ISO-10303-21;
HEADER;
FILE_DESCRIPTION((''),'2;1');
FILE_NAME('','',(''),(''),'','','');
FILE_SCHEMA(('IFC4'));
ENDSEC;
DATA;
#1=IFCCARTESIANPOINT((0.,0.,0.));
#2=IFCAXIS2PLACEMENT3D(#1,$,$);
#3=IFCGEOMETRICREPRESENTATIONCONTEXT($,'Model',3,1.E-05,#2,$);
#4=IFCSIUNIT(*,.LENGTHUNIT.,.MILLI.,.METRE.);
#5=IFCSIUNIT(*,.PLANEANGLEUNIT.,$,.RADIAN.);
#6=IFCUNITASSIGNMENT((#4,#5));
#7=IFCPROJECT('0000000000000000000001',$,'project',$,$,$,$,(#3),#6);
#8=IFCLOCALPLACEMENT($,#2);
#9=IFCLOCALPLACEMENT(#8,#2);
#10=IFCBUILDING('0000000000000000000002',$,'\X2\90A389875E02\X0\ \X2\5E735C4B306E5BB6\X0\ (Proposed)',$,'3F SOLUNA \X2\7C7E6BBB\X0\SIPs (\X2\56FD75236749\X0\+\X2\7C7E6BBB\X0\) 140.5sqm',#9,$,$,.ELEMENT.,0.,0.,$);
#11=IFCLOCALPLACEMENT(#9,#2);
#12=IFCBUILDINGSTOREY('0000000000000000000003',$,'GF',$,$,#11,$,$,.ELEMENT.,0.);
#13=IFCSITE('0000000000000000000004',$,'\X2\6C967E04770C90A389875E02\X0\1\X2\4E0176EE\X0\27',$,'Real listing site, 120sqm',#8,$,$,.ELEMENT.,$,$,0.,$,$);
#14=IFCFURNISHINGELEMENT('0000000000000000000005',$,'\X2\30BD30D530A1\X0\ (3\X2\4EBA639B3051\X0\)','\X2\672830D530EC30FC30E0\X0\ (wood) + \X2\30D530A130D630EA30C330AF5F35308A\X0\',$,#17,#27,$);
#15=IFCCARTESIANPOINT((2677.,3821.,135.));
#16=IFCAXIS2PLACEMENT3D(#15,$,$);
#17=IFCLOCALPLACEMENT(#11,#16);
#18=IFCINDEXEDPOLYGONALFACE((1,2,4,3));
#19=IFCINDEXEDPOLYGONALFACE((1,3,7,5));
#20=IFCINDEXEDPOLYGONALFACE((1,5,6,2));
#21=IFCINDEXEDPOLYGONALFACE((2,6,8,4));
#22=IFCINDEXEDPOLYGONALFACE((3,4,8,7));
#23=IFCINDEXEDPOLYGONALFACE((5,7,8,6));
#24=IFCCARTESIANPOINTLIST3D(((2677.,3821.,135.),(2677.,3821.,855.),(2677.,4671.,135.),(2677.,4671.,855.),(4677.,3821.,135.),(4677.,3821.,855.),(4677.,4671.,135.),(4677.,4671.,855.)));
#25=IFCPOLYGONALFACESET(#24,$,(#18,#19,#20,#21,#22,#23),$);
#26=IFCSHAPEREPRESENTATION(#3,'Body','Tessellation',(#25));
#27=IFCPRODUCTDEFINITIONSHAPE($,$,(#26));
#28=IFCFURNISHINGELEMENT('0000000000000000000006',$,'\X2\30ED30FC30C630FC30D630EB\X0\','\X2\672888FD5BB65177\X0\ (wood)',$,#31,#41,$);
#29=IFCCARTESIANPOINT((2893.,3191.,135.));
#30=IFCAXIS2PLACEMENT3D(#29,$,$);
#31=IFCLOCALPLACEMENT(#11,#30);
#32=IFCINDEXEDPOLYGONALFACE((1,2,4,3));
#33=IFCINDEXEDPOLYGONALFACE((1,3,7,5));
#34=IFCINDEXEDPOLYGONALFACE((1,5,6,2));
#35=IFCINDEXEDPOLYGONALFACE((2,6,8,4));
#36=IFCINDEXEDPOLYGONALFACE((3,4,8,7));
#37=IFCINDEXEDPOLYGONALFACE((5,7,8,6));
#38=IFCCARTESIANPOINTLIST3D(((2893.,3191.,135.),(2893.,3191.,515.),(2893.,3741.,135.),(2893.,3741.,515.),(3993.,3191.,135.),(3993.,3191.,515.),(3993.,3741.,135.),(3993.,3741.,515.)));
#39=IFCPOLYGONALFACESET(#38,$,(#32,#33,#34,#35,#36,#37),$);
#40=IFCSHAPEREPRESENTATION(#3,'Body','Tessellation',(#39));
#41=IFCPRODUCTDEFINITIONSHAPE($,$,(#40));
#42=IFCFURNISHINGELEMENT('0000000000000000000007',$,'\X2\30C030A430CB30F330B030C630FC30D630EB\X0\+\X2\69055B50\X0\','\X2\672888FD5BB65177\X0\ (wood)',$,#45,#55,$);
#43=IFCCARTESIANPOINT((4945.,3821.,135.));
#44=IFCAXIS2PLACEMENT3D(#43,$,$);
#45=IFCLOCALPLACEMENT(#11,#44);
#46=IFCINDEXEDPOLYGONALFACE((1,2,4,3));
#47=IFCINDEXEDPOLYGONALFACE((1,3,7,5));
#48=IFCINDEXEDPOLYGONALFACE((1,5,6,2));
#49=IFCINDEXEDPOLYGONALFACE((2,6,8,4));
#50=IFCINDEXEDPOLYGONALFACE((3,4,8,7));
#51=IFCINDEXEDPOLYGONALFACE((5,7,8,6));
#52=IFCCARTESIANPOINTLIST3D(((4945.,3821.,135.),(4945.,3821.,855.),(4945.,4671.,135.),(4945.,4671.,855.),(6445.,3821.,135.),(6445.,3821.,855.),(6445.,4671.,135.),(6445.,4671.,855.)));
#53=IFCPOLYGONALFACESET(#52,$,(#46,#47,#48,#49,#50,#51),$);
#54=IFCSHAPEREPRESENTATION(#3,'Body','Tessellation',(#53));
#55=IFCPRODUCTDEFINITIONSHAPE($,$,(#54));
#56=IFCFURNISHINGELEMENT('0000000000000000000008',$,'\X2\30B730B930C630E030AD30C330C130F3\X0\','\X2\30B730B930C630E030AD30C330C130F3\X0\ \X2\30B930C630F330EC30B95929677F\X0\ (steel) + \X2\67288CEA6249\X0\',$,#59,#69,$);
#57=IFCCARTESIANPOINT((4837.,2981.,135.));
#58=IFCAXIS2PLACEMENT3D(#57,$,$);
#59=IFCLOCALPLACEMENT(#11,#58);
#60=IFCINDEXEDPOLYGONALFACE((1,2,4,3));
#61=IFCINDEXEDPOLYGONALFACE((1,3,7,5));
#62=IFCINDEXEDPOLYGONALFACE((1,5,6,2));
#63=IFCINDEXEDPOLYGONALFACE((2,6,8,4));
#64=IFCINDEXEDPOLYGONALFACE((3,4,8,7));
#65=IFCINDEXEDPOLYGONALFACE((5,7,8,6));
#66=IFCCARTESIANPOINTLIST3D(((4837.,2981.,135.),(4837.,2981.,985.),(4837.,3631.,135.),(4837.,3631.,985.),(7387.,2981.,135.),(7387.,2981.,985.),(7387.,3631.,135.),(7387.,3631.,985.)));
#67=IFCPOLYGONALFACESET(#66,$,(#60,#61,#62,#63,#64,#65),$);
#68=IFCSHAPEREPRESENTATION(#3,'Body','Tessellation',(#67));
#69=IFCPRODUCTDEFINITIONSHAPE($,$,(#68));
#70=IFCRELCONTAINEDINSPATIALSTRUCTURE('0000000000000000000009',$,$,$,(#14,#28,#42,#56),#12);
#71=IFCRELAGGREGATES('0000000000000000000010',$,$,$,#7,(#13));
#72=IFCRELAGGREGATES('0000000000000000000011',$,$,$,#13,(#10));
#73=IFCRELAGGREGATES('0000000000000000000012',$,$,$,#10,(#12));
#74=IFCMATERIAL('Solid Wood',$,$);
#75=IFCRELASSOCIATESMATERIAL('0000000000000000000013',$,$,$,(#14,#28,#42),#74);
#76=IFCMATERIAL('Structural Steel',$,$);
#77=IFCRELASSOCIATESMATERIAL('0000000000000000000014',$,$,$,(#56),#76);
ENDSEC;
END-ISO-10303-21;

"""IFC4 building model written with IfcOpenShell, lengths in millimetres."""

from ifc_helpers import new_model, si_unit, frame, frame_2d, origin, place, context, project, spatial, rectangle, extrude, material, element, save


model = new_model("IFC4")

# Units and contexts
model_context = context("Model", 3, precision=1e-05, world=origin())
ifc_project = project(units=[si_unit("LENGTHUNIT", "METRE", prefix="MILLI"), si_unit("PLANEANGLEUNIT", "RADIAN")], contexts=[model_context])

# Site, building, storey
site_placement = place(None, origin())
site = spatial("IfcSite", under=ifc_project, at=site_placement, Name="沖縄県那覇市1丁目27", ObjectType="Real listing site, 120sqm", CompositionType="ELEMENT", RefElevation=0.0)
building_placement = place(site_placement, origin())
building = spatial("IfcBuilding", under=site, at=building_placement, Name="那覇市 平屋の家 (Proposed)", ObjectType="3F SOLUNA 籾殻SIPs (国産杉+籾殻) 140.5sqm", CompositionType="ELEMENT", ElevationOfRefHeight=0.0, ElevationOfTerrain=0.0)
storey_placement = place(building_placement, origin())
storey = spatial("IfcBuildingStorey", under=building, at=storey_placement, Name="GF", CompositionType="ELEMENT", Elevation=0.0)

# Shared definitions
ifc_material_1 = material(Name="Solid Wood")

# Furnishing elements
furnishing_1_placement = place(storey_placement, frame((2677.0, 3821.0, 135.0)))
element("IfcFurnishingElement", 1, at=furnishing_1_placement, inside=storey, material=ifc_material_1, Name="ソファ (3人掛け)", Description="木フレーム (wood) + ファブリック張り", context=model_context, shape_type="SweptSolid", body=[
    extrude(rectangle(XDim=2000.0, YDim=850.0, at=frame_2d((1000.0, 425.0))), frame((2677.0, 3821.0, 135.0)), (0.0, 0.0, 1.0), 720.0),
])
furnishing_2_placement = place(storey_placement, frame((2893.0, 3191.0, 135.0)))
element("IfcFurnishingElement", 2, at=furnishing_2_placement, inside=storey, material=ifc_material_1, Name="ローテーブル", Description="木製家具 (wood)", context=model_context, shape_type="SweptSolid", body=[
    extrude(rectangle(XDim=1100.0, YDim=550.0, at=frame_2d((550.0, 275.0))), frame((2893.0, 3191.0, 135.0)), (0.0, 0.0, 1.0), 380.0),
])
furnishing_3_placement = place(storey_placement, frame((4945.0, 3821.0, 135.0)))
element("IfcFurnishingElement", 3, at=furnishing_3_placement, inside=storey, material=ifc_material_1, Name="ダイニングテーブル+椅子", Description="木製家具 (wood)", context=model_context, shape_type="SweptSolid", body=[
    extrude(rectangle(XDim=1500.0, YDim=850.0, at=frame_2d((750.0, 425.0))), frame((4945.0, 3821.0, 135.0)), (0.0, 0.0, 1.0), 720.0),
])
ifc_material_2 = material(Name="Structural Steel")
furnishing_4_placement = place(storey_placement, frame((4837.0, 2981.0, 135.0)))
element("IfcFurnishingElement", 4, at=furnishing_4_placement, inside=storey, material=ifc_material_2, Name="システムキッチン", Description="システムキッチン ステンレス天板 (steel) + 木質扉", context=model_context, shape_type="SweptSolid", body=[
    extrude(rectangle(XDim=2550.0, YDim=650.0, at=frame_2d((1275.0, 325.0))), frame((4837.0, 2981.0, 135.0)), (0.0, 0.0, 1.0), 850.0),
])

save(model, "model.ifc")
